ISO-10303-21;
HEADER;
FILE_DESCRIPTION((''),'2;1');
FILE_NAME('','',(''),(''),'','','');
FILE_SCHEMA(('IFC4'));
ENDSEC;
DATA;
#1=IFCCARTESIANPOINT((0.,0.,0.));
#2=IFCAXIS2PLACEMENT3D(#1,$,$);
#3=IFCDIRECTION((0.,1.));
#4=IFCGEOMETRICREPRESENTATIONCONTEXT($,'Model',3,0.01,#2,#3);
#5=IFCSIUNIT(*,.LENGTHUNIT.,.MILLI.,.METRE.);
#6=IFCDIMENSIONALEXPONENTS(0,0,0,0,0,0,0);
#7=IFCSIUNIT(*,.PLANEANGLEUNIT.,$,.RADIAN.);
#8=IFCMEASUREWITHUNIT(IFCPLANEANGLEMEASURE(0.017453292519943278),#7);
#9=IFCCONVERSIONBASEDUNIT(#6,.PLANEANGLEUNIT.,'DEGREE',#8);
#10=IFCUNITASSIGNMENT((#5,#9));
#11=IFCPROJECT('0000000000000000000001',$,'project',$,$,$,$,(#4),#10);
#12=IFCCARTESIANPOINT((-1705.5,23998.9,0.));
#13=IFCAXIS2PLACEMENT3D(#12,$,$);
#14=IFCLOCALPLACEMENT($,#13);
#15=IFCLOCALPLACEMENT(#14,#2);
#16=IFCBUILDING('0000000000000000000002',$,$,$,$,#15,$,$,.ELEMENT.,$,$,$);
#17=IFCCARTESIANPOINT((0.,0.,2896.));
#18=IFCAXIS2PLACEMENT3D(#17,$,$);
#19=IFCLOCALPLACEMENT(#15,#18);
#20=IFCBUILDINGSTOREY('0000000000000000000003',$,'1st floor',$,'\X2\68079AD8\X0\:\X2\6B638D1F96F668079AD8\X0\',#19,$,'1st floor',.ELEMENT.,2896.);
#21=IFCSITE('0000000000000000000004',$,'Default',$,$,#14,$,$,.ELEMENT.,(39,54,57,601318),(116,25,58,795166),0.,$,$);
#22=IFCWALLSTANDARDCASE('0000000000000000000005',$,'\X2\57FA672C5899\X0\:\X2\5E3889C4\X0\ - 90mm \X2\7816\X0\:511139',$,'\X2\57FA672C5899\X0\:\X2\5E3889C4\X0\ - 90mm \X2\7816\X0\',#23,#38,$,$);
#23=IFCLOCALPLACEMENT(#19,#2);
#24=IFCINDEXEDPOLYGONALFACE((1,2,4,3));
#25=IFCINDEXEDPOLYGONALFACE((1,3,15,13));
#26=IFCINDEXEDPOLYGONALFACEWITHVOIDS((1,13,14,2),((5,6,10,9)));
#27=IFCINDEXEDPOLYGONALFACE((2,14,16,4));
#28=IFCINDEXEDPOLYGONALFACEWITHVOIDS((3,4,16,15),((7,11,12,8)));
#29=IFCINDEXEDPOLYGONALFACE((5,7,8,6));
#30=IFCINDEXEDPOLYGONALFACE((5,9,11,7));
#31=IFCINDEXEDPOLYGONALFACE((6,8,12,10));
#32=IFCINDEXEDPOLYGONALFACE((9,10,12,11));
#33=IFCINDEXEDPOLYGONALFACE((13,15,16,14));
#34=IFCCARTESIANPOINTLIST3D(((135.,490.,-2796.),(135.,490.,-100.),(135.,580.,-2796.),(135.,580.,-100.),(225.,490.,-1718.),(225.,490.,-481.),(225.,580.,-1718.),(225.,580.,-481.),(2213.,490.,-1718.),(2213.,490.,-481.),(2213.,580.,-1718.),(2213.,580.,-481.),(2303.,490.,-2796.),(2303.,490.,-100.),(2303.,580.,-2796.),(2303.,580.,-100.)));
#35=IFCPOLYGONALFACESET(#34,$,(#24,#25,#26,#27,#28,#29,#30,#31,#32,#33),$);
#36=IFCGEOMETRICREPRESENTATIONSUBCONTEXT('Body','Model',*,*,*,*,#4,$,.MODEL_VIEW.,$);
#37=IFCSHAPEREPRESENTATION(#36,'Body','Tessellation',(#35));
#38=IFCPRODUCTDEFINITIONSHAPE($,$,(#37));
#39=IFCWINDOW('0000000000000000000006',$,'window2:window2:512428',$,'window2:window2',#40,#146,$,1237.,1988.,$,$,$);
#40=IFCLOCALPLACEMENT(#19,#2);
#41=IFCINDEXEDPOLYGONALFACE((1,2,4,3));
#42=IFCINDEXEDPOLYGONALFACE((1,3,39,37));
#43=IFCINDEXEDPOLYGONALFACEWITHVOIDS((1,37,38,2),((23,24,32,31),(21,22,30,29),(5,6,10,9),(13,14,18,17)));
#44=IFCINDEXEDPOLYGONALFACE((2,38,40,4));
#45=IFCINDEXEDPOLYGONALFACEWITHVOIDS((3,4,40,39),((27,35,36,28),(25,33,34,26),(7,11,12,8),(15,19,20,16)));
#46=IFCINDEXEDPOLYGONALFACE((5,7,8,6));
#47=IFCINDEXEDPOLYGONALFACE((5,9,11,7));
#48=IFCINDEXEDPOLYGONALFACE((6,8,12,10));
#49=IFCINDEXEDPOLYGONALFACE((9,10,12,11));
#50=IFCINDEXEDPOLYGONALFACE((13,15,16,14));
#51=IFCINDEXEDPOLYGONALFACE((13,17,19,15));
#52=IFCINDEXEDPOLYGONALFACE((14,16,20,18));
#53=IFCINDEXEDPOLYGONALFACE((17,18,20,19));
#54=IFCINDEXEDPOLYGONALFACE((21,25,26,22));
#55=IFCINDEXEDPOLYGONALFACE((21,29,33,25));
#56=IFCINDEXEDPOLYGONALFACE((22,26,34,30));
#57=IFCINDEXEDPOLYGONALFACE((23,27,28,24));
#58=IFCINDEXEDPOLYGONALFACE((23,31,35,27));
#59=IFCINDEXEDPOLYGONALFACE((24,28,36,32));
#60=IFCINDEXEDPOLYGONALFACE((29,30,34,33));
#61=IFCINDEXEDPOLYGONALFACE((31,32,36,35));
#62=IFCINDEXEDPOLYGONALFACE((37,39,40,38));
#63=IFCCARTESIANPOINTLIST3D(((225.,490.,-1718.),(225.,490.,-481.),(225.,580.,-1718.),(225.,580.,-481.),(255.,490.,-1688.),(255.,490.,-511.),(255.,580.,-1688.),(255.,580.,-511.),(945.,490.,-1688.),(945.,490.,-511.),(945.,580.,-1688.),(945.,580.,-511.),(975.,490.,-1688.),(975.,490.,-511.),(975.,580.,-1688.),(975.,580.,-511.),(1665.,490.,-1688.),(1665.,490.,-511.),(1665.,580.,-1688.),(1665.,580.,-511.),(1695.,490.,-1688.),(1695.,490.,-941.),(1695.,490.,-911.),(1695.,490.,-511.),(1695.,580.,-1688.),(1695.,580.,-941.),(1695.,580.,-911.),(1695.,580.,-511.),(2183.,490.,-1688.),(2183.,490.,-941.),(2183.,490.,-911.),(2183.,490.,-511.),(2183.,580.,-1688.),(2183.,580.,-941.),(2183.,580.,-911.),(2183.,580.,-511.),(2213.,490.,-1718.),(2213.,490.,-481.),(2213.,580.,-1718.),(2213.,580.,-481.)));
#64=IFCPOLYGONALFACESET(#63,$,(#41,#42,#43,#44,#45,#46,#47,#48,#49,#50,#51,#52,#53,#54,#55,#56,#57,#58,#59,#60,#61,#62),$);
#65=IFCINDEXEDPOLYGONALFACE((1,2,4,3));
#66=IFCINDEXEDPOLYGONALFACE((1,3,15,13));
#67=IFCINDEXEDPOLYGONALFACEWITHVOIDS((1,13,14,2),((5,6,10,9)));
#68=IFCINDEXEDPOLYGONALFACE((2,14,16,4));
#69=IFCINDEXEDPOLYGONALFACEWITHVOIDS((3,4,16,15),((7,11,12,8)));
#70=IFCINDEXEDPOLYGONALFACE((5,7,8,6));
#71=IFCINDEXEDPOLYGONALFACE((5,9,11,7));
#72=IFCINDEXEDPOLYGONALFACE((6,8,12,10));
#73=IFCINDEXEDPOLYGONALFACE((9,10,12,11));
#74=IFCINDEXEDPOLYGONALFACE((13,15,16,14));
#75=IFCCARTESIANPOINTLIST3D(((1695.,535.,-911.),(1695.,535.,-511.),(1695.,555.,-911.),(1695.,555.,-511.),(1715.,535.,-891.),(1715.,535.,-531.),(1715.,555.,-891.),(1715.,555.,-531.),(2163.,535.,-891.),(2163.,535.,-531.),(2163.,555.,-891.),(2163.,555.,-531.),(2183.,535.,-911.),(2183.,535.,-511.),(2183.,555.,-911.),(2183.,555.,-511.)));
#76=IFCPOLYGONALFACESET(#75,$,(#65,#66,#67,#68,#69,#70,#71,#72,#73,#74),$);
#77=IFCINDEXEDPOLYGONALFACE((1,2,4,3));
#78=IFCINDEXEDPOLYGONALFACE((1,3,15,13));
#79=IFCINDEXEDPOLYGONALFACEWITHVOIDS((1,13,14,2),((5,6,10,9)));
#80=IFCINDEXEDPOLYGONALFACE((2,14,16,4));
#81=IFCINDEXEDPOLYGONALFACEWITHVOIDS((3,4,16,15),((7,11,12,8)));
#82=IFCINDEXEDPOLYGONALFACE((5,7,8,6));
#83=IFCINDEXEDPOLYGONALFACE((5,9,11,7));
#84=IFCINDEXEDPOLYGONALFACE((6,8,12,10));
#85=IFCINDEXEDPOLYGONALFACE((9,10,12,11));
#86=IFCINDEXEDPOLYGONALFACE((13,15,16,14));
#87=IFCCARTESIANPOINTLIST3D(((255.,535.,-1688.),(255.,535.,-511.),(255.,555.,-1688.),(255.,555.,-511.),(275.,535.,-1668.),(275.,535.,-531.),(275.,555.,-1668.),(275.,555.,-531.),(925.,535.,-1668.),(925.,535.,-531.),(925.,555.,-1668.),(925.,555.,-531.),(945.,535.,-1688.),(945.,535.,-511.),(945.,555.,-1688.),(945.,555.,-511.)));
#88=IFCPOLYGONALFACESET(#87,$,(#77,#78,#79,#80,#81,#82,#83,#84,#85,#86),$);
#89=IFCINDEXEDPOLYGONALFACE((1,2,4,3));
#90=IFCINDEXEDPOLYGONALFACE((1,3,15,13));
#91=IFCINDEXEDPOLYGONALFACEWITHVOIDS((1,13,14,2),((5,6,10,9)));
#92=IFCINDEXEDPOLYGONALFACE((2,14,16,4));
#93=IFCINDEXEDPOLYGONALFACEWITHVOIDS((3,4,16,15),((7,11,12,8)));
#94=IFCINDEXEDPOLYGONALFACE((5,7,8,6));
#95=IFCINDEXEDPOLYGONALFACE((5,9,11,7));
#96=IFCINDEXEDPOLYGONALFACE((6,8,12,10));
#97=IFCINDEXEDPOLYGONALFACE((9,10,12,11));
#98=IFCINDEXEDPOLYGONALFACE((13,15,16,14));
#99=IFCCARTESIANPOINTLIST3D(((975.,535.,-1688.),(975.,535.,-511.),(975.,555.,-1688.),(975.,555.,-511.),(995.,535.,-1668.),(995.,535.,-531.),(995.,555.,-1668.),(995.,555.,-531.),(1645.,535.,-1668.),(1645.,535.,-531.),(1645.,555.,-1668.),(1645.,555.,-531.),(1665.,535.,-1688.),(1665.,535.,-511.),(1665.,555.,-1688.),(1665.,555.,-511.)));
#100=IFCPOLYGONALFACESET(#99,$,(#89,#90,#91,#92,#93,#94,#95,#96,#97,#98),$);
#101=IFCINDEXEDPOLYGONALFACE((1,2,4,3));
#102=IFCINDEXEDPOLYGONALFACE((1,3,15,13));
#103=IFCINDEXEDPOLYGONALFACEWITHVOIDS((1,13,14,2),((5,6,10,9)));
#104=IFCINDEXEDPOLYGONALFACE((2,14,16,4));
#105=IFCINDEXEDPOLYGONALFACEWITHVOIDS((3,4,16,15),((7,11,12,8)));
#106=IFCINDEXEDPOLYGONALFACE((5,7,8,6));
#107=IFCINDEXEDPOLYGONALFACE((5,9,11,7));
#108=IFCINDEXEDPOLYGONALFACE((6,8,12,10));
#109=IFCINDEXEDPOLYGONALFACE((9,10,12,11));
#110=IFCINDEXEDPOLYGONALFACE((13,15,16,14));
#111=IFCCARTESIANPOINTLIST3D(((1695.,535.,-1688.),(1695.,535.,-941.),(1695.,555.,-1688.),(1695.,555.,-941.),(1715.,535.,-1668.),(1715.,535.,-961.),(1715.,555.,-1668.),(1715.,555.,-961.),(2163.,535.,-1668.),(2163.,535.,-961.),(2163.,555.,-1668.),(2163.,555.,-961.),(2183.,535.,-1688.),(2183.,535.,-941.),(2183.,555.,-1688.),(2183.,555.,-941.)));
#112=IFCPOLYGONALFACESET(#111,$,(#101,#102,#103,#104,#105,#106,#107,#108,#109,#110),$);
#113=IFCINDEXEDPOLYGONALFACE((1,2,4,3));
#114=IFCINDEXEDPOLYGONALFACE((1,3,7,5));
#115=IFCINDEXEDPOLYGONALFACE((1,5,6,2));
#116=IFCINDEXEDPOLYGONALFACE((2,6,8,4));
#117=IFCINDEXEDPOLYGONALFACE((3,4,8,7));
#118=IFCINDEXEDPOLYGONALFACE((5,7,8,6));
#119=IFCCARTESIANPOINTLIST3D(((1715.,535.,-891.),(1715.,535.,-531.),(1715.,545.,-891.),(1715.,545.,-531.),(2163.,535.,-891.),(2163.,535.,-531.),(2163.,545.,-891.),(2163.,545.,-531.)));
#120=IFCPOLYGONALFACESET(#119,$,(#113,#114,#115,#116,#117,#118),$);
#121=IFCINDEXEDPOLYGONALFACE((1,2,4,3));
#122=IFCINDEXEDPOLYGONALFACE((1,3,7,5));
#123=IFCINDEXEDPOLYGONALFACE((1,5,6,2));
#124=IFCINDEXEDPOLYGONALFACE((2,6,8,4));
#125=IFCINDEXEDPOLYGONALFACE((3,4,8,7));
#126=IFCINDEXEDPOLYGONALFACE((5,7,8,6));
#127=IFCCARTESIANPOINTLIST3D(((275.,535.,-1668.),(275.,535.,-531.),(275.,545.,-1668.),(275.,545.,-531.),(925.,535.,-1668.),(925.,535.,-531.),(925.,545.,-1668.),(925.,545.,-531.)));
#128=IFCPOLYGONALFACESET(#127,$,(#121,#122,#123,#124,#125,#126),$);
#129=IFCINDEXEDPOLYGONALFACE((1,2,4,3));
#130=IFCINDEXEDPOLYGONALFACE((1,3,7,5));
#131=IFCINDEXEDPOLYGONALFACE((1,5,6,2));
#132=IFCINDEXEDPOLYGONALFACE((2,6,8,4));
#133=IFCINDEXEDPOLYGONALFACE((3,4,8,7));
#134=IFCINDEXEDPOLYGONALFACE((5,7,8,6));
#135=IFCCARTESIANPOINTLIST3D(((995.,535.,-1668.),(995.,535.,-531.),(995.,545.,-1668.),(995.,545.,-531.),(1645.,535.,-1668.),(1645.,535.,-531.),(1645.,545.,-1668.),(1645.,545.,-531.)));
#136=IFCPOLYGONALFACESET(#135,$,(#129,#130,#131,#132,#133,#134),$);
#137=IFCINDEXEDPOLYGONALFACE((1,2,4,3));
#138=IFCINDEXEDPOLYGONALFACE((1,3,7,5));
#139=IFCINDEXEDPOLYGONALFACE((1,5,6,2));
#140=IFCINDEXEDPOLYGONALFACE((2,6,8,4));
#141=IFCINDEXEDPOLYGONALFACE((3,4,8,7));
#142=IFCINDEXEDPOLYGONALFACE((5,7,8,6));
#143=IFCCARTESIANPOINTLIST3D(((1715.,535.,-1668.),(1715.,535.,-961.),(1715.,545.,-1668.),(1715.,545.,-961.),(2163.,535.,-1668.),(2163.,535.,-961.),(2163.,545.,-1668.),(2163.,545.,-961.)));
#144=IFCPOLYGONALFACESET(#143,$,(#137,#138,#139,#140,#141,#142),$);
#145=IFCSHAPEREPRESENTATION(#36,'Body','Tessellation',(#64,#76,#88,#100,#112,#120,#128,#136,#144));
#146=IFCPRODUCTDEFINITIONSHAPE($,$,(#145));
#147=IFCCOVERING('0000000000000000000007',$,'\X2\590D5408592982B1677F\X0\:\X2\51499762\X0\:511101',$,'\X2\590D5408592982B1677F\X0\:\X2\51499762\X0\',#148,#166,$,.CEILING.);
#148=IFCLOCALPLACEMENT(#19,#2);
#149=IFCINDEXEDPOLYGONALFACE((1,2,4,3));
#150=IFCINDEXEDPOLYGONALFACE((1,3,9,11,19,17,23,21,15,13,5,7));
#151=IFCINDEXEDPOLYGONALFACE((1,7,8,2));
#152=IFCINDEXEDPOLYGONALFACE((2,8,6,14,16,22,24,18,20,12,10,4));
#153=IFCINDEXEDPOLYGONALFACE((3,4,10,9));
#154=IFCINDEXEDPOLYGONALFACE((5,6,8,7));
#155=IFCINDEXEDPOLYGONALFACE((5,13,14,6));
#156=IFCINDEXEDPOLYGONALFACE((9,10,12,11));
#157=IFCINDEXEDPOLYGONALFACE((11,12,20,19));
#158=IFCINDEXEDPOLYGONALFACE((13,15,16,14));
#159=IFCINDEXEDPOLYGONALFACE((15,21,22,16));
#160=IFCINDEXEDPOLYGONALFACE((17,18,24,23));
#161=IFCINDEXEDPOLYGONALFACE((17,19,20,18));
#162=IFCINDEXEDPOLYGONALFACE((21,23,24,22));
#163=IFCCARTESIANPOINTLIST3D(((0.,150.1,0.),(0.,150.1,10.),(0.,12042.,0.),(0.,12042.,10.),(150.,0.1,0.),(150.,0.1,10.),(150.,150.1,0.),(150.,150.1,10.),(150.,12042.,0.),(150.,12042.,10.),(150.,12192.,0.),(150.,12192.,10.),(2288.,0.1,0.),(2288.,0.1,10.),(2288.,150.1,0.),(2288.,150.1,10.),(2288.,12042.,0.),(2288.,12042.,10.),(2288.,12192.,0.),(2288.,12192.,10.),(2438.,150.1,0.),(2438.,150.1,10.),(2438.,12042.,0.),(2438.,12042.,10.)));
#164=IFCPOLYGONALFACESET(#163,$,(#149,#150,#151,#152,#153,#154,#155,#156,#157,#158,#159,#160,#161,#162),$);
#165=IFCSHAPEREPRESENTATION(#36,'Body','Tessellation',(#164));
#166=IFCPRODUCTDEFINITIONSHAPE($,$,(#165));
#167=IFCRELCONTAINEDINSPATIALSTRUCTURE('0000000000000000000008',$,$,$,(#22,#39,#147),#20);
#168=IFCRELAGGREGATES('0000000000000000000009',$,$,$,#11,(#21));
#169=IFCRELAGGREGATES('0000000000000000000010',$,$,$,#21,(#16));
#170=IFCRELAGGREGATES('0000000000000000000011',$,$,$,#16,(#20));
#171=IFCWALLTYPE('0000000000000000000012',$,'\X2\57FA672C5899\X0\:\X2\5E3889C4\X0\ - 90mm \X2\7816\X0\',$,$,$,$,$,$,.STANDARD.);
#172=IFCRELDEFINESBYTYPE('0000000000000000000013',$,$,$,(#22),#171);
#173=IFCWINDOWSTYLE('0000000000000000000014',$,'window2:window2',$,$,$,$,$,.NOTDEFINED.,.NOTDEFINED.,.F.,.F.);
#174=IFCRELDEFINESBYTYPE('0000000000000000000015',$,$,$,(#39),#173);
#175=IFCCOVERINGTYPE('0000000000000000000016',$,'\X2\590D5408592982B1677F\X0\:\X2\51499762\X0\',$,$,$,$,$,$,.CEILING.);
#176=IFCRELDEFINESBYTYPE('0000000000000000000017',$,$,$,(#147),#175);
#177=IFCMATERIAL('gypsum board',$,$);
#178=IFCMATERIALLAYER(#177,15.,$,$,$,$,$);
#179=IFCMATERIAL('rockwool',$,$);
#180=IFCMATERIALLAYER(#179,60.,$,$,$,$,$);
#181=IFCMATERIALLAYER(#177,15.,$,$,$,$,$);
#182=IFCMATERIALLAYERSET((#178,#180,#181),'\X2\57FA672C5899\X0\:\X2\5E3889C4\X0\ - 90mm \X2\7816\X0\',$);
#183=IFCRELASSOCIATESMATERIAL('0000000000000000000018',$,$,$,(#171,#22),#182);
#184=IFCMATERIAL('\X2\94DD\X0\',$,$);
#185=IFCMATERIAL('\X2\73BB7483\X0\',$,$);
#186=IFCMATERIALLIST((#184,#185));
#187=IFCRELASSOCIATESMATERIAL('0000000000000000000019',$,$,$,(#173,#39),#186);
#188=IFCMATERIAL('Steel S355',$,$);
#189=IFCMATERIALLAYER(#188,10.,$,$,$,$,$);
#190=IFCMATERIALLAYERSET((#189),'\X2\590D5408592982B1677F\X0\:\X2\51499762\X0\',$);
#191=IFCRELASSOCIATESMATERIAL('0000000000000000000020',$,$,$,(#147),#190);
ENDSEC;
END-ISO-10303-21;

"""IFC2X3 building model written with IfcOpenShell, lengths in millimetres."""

from ifc_helpers import new_model, entity, si_unit, converted_unit, direction, frame, frame_2d, origin, origin_2d_with_axis, place, context, subcontext, project, spatial, polyline, rectangle, outline, extrude, source, transform, mapped, material, material_list, layer, layer_set, layer_usage, type_object, type_shapes, element, fill, save


model = new_model("IFC2X3")

# Units and contexts
model_context = context("Model", 3, precision=0.01, world=origin(), true_north=direction((0.0, 1.0)))
body_context = subcontext(model_context, "Body", "Model", "MODEL_VIEW")
ifc_project = project(units=[si_unit("LENGTHUNIT", "METRE", prefix="MILLI"), converted_unit("PLANEANGLEUNIT", "DEGREE", entity("IfcPlaneAngleMeasure", 0.017453292519943278), si_unit("PLANEANGLEUNIT", "RADIAN"), dimensions=[0, 0, 0, 0, 0, 0, 0])], contexts=[model_context])

# Site, building, storey
site_placement = place(None, frame((-1705.5, 23998.9, 0.0)))
site = spatial("IfcSite", under=ifc_project, at=site_placement, Name="Default", CompositionType="ELEMENT", RefLatitude=(39, 54, 57, 601318), RefLongitude=(116, 25, 58, 795166), RefElevation=0.0)
building_placement = place(site_placement, origin())
building = spatial("IfcBuilding", under=site, at=building_placement, CompositionType="ELEMENT")
storey_placement = place(building_placement, frame((0.0, 0.0, 2896.0)))
storey = spatial("IfcBuildingStorey", under=building, at=storey_placement, Name="1st floor", ObjectType="标高:正负零标高", LongName="1st floor", CompositionType="ELEMENT", Elevation=2896.0)

# Shared definitions
ifc_material_1 = material(Name="Steel S355")

# Wall, opening, window
ifc_material_2 = material(Name="gypsum board")
ifc_layer_1 = layer(ifc_material_2, 15.0)
ifc_material_3 = material(Name="rockwool")
ifc_layer_2 = layer(ifc_material_3, 60.0)
ifc_layer_3 = layer(ifc_material_2, 15.0)
ifc_layer_set_1 = layer_set([ifc_layer_1, ifc_layer_2, ifc_layer_3], Name="基本墙:常规 - 90mm 砖")
ifc_layer_usage_1 = layer_usage(ifc_layer_set_1, "AXIS2", "NEGATIVE", 45.0)
wall_type = type_object("IfcWallType", Name="基本墙:常规 - 90mm 砖", PredefinedType="STANDARD", material=ifc_layer_set_1)
wall_placement = place(storey_placement, frame((2303.0, 535.0, -2796.0), z_axis=(0.0, 0.0, 1.0), x_axis=(-1.0, 0.0, 0.0)))
wall = element("IfcWallStandardCase", 1, at=wall_placement, inside=storey, type_object=wall_type, material=ifc_layer_usage_1, Name="基本墙:常规 - 90mm 砖:511139", ObjectType="基本墙:常规 - 90mm 砖", context=body_context, shape_type="SweptSolid", body=[
    extrude(rectangle(XDim=2168.0, YDim=90.0, at=frame_2d((1084.0, 0.0), x_axis=(-1.0, 0.0))), origin(), (0.0, 0.0, 1.0), 2696.0),
])
opening_1_placement = place(wall_placement, frame((90.0, -45.0, 1078.0)))
opening_1 = element("IfcOpeningElement", 2, at=opening_1_placement, cuts=wall, ObjectType="Opening", context=body_context, shape_type="SweptSolid", body=[
    extrude(rectangle(XDim=1237.0, YDim=1988.0, at=frame_2d((618.5, 994.0), x_axis=(1.0, 0.0))), frame((0.0, 0.0, 0.0), z_axis=(0.0, 1.0, 0.0), x_axis=(0.0, 0.0, 1.0)), (0.0, 0.0, 1.0), 90.0),
])
ifc_material_4 = material(Name="铝")
ifc_material_5 = material(Name="玻璃")
ifc_material_list = material_list([ifc_material_4, ifc_material_5])
window_style = type_object("IfcWindowStyle", Name="window2:window2", ConstructionType="NOTDEFINED", OperationType="NOTDEFINED", ParameterTakesPrecedence=False, Sizeable=False, material=ifc_material_list)
shared_shape_1 = source(origin(), body_context, "Body", "SweptSolid", [
    extrude(outline(polyline([(-994.0, -618.5), (994.0, -618.5), (994.0, 618.5), (-994.0, 618.5), (-994.0, -618.5)]), holes=[polyline([(274.0, 588.5), (964.0, 588.5), (964.0, -588.5), (274.0, -588.5), (274.0, 588.5)]), polyline([(-446.0, 588.5), (244.0, 588.5), (244.0, -588.5), (-446.0, -588.5), (-446.0, 588.5)]), polyline([(-964.0, -588.5), (-964.0, 158.5), (-476.0, 158.5), (-476.0, -588.5), (-964.0, -588.5)]), polyline([(-964.0, 588.5), (-476.0, 588.5), (-476.0, 188.5), (-964.0, 188.5), (-964.0, 588.5)])]), frame((994.0, 90.0, 618.5), z_axis=(0.0, -1.0, 0.0), x_axis=(1.0, 0.0, 0.0)), (0.0, 0.0, 1.0), 90.0),
    extrude(outline(polyline([(-200.0, -244.0), (200.0, -244.0), (200.0, 244.0), (-200.0, 244.0), (-200.0, -244.0)]), holes=[polyline([(-180.0, -224.0), (-180.0, 224.0), (180.0, 224.0), (180.0, -224.0), (-180.0, -224.0)])]), frame((274.0, 45.0, 1007.0), z_axis=(0.0, -1.0, 0.0), x_axis=(0.0, 0.0, -1.0)), (0.0, 0.0, 1.0), 20.0),
    extrude(outline(polyline([(-588.5, -345.0), (588.5, -345.0), (588.5, 345.0), (-588.5, 345.0), (-588.5, -345.0)]), holes=[polyline([(-568.5, -325.0), (-568.5, 325.0), (568.5, 325.0), (568.5, -325.0), (-568.5, -325.0)])]), frame((1613.0, 45.0, 618.5), z_axis=(0.0, -1.0, 0.0), x_axis=(0.0, 0.0, -1.0)), (0.0, 0.0, 1.0), 20.0),
    extrude(outline(polyline([(-588.5, -345.0), (588.5, -345.0), (588.5, 345.0), (-588.5, 345.0), (-588.5, -345.0)]), holes=[polyline([(-568.5, -325.0), (-568.5, 325.0), (568.5, 325.0), (568.5, -325.0), (-568.5, -325.0)])]), frame((893.0, 45.0, 618.5), z_axis=(0.0, -1.0, 0.0), x_axis=(0.0, 0.0, -1.0)), (0.0, 0.0, 1.0), 20.0),
    extrude(outline(polyline([(-373.5, -244.0), (373.5, -244.0), (373.5, 244.0), (-373.5, 244.0), (-373.5, -244.0)]), holes=[polyline([(-353.5, -224.0), (-353.5, 224.0), (353.5, 224.0), (353.5, -224.0), (-353.5, -224.0)])]), frame((274.0, 45.0, 403.5), z_axis=(0.0, -1.0, 0.0), x_axis=(0.0, 0.0, -1.0)), (0.0, 0.0, 1.0), 20.0),
    extrude(rectangle(XDim=448.0, YDim=10.0, at=frame_2d((0.0, 0.0), x_axis=(1.0, 0.0))), frame((274.0, 40.0, 827.0)), (0.0, 0.0, 1.0), 360.0),
    extrude(rectangle(XDim=650.0, YDim=10.0, at=origin_2d_with_axis()), frame((1613.0, 40.0, 50.0)), (0.0, 0.0, 1.0), 1137.0),
    extrude(rectangle(XDim=650.0, YDim=10.0, at=origin_2d_with_axis()), frame((893.0, 40.0, 50.0)), (0.0, 0.0, 1.0), 1137.0),
    extrude(rectangle(XDim=448.0, YDim=10.0, at=frame_2d((0.0, 0.0), x_axis=(1.0, 0.0))), frame((274.0, 40.0, 50.0)), (0.0, 0.0, 1.0), 707.0),
])
type_shapes(window_style, [shared_shape_1])
window_placement = place(opening_1_placement, origin())
window = element("IfcWindow", 3, at=window_placement, inside=storey, type_object=window_style, material=ifc_material_list, Name="window2:window2:512428", ObjectType="window2:window2", OverallHeight=1237.0, OverallWidth=1988.0, context=body_context, shape_type="MappedRepresentation", body=[
    mapped(shared_shape_1, transform((0.0, 0.0, 0.0), scale=1.0)),
])
fill(opening_1, window)

# Covering
ifc_layer_4 = layer(ifc_material_1, 10.0)
ifc_layer_set_2 = layer_set([ifc_layer_4], Name="复合天花板:光面")
ifc_layer_usage_2 = layer_usage(ifc_layer_set_2, "AXIS3", "NEGATIVE", 10.0)
covering_type = type_object("IfcCoveringType", Name="复合天花板:光面", PredefinedType="CEILING")
covering_placement = place(storey_placement, origin())
element("IfcCovering", 4, at=covering_placement, inside=storey, type_object=covering_type, material=ifc_layer_usage_2, Name="复合天花板:光面:511101", ObjectType="复合天花板:光面", PredefinedType="CEILING", context=body_context, shape_type="SweptSolid", body=[
    extrude(outline(polyline([(5946.0, -1069.0), (6096.0, -1069.0), (6096.0, 1069.0), (5945.9, 1069.0), (5945.9, 1219.0), (-5946.0, 1219.0), (-5946.0, 1069.0), (-6096.0, 1069.0), (-6096.0, -1069.0), (-5946.0, -1069.0), (-5946.0, -1219.0), (5946.0, -1219.0), (5946.0, -1069.0)])), frame((1219.0, 6096.0, 0.0), z_axis=(0.0, 0.0, 1.0), x_axis=(0.0, 1.0, 0.0)), (0.0, 0.0, 1.0), 10.0),
])

save(model, "model.ifc")
